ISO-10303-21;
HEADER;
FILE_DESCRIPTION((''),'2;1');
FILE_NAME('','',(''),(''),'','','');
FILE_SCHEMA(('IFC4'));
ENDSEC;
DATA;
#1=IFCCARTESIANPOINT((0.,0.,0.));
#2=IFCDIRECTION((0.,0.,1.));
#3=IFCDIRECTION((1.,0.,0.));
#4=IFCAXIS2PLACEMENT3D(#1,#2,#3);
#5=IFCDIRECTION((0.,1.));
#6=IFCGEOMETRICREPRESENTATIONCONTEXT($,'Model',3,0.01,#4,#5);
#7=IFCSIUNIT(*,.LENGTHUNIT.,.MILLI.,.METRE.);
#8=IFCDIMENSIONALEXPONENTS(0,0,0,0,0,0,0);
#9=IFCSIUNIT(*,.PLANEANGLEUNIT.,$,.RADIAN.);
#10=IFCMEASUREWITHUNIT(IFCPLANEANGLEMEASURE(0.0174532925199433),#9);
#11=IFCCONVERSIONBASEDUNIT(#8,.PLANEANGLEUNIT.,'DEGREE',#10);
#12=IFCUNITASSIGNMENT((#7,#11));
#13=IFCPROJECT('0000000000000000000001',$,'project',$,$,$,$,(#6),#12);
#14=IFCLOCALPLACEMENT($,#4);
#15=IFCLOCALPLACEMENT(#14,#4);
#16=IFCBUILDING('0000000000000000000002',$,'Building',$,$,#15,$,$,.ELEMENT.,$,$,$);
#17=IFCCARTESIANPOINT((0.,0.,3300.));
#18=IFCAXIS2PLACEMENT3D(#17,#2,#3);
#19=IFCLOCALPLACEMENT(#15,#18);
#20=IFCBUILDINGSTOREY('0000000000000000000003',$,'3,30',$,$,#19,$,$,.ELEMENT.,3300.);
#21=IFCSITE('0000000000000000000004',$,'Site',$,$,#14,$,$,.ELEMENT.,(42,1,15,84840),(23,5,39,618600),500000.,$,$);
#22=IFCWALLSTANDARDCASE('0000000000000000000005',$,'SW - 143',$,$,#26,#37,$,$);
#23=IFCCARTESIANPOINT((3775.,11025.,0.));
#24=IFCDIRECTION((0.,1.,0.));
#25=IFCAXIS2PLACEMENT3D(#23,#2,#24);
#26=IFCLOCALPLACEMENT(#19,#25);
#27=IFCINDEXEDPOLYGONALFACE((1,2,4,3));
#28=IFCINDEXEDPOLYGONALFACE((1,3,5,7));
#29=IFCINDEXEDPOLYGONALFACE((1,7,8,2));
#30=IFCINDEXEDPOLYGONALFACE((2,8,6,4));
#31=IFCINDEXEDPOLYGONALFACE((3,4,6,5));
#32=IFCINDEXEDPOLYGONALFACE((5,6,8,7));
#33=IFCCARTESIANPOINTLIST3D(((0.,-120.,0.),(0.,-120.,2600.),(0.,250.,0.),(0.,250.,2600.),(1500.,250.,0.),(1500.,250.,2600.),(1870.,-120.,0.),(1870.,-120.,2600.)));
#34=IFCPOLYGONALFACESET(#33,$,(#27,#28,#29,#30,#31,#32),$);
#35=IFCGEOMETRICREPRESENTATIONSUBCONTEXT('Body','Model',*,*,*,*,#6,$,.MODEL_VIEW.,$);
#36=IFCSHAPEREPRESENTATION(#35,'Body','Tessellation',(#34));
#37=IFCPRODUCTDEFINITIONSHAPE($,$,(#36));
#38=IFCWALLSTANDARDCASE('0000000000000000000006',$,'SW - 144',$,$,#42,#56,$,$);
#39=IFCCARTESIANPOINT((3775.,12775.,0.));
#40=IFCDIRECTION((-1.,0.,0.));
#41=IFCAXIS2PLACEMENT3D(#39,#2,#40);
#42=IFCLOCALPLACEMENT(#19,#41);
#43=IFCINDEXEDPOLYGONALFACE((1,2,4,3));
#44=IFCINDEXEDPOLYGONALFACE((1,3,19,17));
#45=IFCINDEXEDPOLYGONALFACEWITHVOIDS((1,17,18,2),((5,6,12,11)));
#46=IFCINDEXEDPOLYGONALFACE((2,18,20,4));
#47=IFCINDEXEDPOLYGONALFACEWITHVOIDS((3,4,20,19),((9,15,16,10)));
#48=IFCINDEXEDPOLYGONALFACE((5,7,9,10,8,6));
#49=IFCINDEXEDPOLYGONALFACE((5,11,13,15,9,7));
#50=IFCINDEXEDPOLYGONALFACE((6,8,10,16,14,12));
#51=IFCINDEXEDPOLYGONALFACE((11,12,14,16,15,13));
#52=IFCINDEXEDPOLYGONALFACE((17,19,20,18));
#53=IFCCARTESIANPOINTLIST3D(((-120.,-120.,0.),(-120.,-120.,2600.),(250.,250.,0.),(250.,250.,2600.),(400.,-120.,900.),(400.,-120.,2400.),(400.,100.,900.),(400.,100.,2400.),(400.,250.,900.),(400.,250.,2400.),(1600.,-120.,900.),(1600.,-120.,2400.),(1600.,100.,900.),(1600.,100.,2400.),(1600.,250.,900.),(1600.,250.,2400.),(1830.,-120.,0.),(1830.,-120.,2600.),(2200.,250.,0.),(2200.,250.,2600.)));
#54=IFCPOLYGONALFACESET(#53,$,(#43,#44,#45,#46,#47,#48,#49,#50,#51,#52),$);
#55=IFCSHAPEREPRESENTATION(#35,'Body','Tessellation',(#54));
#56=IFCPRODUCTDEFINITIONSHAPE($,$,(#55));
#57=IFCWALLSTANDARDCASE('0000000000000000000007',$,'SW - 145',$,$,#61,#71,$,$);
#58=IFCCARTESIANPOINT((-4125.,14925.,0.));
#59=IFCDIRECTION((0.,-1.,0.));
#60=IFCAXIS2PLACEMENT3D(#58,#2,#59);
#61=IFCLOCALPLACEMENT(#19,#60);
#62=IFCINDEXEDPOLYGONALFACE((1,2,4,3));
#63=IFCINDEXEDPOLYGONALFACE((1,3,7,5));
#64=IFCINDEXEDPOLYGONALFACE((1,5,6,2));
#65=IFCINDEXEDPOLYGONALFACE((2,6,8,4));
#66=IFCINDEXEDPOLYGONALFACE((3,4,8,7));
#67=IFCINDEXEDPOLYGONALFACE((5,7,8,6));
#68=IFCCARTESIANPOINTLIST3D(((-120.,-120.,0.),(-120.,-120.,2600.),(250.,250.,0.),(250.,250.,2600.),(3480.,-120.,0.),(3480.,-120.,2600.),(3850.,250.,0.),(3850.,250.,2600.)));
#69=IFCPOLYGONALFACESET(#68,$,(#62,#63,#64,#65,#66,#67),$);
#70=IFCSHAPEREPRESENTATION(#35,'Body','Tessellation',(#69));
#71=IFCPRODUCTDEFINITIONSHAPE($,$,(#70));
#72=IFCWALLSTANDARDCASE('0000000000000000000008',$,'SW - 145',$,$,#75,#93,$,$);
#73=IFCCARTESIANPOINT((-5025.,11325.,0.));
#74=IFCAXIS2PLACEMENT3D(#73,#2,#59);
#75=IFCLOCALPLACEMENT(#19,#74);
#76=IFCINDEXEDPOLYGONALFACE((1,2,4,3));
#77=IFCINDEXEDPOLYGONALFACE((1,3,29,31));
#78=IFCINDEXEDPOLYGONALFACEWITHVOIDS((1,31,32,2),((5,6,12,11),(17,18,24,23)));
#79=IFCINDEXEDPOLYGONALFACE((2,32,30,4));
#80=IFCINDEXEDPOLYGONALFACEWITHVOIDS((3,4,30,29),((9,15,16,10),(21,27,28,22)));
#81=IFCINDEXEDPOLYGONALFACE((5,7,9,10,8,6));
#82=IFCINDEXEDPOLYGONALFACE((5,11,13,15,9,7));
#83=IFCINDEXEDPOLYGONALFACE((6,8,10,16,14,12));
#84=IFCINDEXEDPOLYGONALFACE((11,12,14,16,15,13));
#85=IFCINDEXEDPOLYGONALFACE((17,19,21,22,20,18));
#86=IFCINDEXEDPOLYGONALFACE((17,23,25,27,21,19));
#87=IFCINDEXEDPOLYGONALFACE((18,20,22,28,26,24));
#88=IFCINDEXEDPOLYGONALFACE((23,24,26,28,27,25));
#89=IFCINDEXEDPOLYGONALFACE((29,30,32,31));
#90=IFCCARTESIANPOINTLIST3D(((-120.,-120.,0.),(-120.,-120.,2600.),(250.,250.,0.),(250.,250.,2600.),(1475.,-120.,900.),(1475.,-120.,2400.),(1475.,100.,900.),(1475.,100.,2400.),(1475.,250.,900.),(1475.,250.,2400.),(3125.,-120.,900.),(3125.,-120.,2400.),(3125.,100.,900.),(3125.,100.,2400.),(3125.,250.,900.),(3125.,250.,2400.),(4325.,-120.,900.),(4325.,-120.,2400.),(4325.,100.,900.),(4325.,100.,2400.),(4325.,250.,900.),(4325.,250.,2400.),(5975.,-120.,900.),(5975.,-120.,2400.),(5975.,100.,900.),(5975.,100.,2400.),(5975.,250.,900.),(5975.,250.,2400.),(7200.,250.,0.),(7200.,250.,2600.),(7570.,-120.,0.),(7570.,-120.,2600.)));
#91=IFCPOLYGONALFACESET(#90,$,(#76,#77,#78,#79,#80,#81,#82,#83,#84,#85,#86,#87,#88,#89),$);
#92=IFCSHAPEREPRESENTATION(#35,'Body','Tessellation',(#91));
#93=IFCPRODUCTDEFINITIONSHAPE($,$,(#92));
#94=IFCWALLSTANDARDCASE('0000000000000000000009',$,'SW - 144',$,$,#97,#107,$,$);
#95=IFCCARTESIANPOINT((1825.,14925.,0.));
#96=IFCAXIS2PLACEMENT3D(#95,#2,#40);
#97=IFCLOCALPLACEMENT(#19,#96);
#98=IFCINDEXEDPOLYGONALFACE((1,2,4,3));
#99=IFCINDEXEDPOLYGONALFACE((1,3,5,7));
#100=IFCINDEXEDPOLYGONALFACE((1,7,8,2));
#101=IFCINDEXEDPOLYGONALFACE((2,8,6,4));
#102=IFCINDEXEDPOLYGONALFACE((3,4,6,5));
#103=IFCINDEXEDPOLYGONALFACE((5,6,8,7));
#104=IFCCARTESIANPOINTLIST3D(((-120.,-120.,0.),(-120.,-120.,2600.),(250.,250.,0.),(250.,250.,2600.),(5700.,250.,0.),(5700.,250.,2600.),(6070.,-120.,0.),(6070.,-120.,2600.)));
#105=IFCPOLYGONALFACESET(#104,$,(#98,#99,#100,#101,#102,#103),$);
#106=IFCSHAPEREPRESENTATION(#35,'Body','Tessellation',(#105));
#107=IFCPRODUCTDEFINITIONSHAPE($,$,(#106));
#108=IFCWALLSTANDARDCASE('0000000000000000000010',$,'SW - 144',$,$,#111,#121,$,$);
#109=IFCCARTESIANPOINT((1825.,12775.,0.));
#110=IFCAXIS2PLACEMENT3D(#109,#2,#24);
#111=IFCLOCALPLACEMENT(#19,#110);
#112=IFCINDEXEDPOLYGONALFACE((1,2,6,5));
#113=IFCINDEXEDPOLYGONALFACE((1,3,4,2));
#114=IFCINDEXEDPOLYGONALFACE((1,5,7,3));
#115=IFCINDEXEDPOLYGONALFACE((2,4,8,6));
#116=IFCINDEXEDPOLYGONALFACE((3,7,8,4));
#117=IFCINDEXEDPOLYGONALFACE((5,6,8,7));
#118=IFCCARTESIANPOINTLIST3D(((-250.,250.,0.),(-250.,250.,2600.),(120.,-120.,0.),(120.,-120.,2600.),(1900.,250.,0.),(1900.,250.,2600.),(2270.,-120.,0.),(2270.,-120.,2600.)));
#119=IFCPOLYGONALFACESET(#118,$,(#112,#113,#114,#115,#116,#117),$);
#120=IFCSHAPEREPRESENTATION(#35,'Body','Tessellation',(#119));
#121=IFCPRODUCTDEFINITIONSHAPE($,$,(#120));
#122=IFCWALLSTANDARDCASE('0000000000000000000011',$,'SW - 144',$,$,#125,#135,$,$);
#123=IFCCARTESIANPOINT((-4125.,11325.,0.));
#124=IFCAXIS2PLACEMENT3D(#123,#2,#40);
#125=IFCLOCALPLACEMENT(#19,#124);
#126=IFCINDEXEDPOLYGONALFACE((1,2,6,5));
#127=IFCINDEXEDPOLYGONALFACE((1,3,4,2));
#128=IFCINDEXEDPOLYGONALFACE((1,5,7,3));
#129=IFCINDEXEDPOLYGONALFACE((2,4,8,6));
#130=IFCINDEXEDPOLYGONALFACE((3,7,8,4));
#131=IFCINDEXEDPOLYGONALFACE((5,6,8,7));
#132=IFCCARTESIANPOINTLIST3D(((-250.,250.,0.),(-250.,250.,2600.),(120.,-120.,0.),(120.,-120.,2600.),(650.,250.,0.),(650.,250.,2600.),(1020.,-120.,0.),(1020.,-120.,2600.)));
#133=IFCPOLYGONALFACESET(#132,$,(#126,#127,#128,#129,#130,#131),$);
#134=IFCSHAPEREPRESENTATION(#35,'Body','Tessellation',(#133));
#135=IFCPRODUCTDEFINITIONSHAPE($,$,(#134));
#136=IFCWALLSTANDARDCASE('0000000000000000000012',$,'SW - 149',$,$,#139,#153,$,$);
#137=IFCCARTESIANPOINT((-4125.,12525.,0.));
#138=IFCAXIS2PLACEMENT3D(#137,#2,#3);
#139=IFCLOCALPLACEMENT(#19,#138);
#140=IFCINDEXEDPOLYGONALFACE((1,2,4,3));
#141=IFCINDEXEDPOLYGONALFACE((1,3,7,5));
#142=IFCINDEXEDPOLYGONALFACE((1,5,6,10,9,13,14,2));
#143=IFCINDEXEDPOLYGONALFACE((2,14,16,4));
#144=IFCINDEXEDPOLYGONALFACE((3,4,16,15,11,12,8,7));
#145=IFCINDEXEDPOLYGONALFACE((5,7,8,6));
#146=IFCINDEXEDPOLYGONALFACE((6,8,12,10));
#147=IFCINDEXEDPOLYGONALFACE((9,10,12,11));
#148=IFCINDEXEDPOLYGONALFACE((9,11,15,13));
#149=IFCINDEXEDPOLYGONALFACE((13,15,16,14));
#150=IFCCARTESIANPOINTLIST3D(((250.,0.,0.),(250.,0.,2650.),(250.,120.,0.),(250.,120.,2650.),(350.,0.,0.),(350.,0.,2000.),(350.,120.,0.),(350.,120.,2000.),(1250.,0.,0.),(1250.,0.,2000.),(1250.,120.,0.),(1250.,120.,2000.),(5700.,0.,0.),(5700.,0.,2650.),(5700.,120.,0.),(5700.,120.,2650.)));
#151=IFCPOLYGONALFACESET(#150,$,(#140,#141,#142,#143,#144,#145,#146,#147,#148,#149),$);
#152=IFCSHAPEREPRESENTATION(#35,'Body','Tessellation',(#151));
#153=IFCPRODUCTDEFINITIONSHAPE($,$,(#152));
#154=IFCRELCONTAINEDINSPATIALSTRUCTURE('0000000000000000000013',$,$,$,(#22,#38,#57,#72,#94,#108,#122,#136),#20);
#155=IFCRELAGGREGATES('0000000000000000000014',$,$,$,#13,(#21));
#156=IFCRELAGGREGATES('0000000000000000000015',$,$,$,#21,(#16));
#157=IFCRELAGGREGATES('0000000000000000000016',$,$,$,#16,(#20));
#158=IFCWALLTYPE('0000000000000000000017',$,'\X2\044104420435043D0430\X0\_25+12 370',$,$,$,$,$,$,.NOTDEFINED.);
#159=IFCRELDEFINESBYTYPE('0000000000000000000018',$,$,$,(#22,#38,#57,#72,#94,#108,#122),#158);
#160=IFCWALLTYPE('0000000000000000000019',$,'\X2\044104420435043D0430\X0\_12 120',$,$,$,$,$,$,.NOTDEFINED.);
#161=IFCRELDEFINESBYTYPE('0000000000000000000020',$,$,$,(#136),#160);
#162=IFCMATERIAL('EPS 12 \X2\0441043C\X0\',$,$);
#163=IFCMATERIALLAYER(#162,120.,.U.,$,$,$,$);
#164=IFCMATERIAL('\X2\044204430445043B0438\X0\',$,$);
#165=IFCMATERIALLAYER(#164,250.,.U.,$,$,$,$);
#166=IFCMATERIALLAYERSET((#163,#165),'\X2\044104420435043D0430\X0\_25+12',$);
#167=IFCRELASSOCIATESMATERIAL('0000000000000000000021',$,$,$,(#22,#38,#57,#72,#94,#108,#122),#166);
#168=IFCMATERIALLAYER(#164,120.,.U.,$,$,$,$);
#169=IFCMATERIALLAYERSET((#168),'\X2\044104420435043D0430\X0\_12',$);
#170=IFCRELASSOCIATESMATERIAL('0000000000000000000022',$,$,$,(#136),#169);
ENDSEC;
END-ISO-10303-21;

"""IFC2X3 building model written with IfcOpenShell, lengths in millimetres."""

from ifc_helpers import new_model, entity, si_unit, converted_unit, direction, frame, origin_with_axes, origin_2d_with_axis, place, context, subcontext, project, spatial, polyline, rectangle, outline, extrude, material, layer, layer_set, layer_usage, type_object, element, save


model = new_model("IFC2X3")

# Units and contexts
model_context = context("Model", 3, precision=0.01, world=origin_with_axes(), true_north=direction((0.0, 1.0)))
body_context = subcontext(model_context, "Body", "Model", "MODEL_VIEW")
ifc_project = project(units=[si_unit("LENGTHUNIT", "METRE", prefix="MILLI"), converted_unit("PLANEANGLEUNIT", "DEGREE", entity("IfcPlaneAngleMeasure", 0.0174532925199433), si_unit("PLANEANGLEUNIT", "RADIAN"), dimensions=[0, 0, 0, 0, 0, 0, 0])], contexts=[model_context])

# Site, building, storey
site_placement = place(None, origin_with_axes())
site = spatial("IfcSite", under=ifc_project, at=site_placement, Name="Site", CompositionType="ELEMENT", RefLatitude=(42, 1, 15, 84840), RefLongitude=(23, 5, 39, 618600), RefElevation=500000.0)
building_placement = place(site_placement, origin_with_axes())
building = spatial("IfcBuilding", under=site, at=building_placement, Name="Building", CompositionType="ELEMENT")
storey_placement = place(building_placement, frame((0.0, 0.0, 3300.0), z_axis=(0.0, 0.0, 1.0), x_axis=(1.0, 0.0, 0.0)))
storey = spatial("IfcBuildingStorey", under=building, at=storey_placement, Name="3,30", CompositionType="ELEMENT", Elevation=3300.0)

# Wall
ifc_material_1 = material(Name="EPS 12 см")
ifc_layer_1 = layer(ifc_material_1, 120.0, ventilated="UNKNOWN")
ifc_material_2 = material(Name="тухли")
ifc_layer_2 = layer(ifc_material_2, 250.0, ventilated="UNKNOWN")
ifc_layer_set_1 = layer_set([ifc_layer_1, ifc_layer_2], Name="стена_25+12")
ifc_layer_usage_1 = layer_usage(ifc_layer_set_1, "AXIS2", "POSITIVE", -120.0)
wall_type_1 = type_object("IfcWallType", Name="стена_25+12 370", PredefinedType="NOTDEFINED")
wall_1_placement = place(storey_placement, frame((3775.0, 11025.0, 0.0), z_axis=(0.0, 0.0, 1.0), x_axis=(0.0, 1.0, 0.0)))
element("IfcWallStandardCase", 1, at=wall_1_placement, inside=storey, type_object=wall_type_1, material=ifc_layer_usage_1, Name="SW - 143", context=body_context, shape_type="SweptSolid", body=[
    extrude(outline(polyline([(0.0, -120.0), (1870.0, -120.0), (1500.0, 250.0), (0.0, 250.0), (0.0, -120.0)])), origin_with_axes(), (0.0, 0.0, 1.0), 2600.0),
])

# Wall, opening
ifc_layer_usage_2 = layer_usage(ifc_layer_set_1, "AXIS2", "POSITIVE", -120.0)
wall_2_placement = place(storey_placement, frame((3775.0, 12775.0, 0.0), z_axis=(0.0, 0.0, 1.0), x_axis=(-1.0, 0.0, 0.0)))
wall_2 = element("IfcWallStandardCase", 2, at=wall_2_placement, inside=storey, type_object=wall_type_1, material=ifc_layer_usage_2, Name="SW - 144", context=body_context, shape_type="SweptSolid", body=[
    extrude(outline(polyline([(-120.0, -120.0), (1830.0, -120.0), (2200.0, 250.0), (250.0, 250.0), (-120.0, -120.0)])), origin_with_axes(), (0.0, 0.0, 1.0), 2600.0),
])
opening_1_placement = place(wall_2_placement, frame((1000.0, 0.0, 900.0), z_axis=(0.0, 0.0, 1.0), x_axis=(1.0, 0.0, 0.0)))
element("IfcOpeningElement", 3, at=opening_1_placement, cuts=wall_2, context=body_context, shape_type="SweptSolid", body=[
    extrude(rectangle(XDim=1200.0, YDim=1500.0, at=origin_2d_with_axis()), frame((0.0, 100.0, 750.0), z_axis=(0.0, -1.0, 0.0), x_axis=(-1.0, 0.0, 0.0)), (0.0, 0.0, 1.0), 590.0),
    extrude(rectangle(XDim=1200.0, YDim=1500.0, at=origin_2d_with_axis()), frame((0.0, 100.0, 750.0), z_axis=(0.0, 1.0, 0.0), x_axis=(-1.0, 0.0, 0.0)), (0.0, 0.0, 1.0), 520.0),
])

# Wall
ifc_layer_usage_3 = layer_usage(ifc_layer_set_1, "AXIS2", "POSITIVE", -120.0)
wall_3_placement = place(storey_placement, frame((-4125.0, 14925.0, 0.0), z_axis=(0.0, 0.0, 1.0), x_axis=(0.0, -1.0, 0.0)))
element("IfcWallStandardCase", 4, at=wall_3_placement, inside=storey, type_object=wall_type_1, material=ifc_layer_usage_3, Name="SW - 145", context=body_context, shape_type="SweptSolid", body=[
    extrude(outline(polyline([(-120.0, -120.0), (3480.0, -120.0), (3850.0, 250.0), (250.0, 250.0), (-120.0, -120.0)])), origin_with_axes(), (0.0, 0.0, 1.0), 2600.0),
])

# Wall, openings
ifc_layer_usage_4 = layer_usage(ifc_layer_set_1, "AXIS2", "POSITIVE", -120.0)
wall_4_placement = place(storey_placement, frame((-5025.0, 11325.0, 0.0), z_axis=(0.0, 0.0, 1.0), x_axis=(0.0, -1.0, 0.0)))
wall_4 = element("IfcWallStandardCase", 5, at=wall_4_placement, inside=storey, type_object=wall_type_1, material=ifc_layer_usage_4, Name="SW - 145", context=body_context, shape_type="SweptSolid", body=[
    extrude(outline(polyline([(-120.0, -120.0), (7570.0, -120.0), (7200.0, 250.0), (250.0, 250.0), (-120.0, -120.0)])), origin_with_axes(), (0.0, 0.0, 1.0), 2600.0),
])
opening_2_placement = place(wall_4_placement, frame((2300.0, 0.0, 900.0), z_axis=(0.0, 0.0, 1.0), x_axis=(1.0, 0.0, 0.0)))
element("IfcOpeningElement", 6, at=opening_2_placement, cuts=wall_4, context=body_context, shape_type="SweptSolid", body=[
    extrude(rectangle(XDim=1650.0, YDim=1500.0, at=origin_2d_with_axis()), frame((0.0, 100.0, 750.0), z_axis=(0.0, 1.0, 0.0), x_axis=(1.0, 0.0, 0.0)), (0.0, 0.0, -1.0), 590.0),
    extrude(rectangle(XDim=1650.0, YDim=1500.0, at=origin_2d_with_axis()), frame((0.0, 100.0, 750.0), z_axis=(0.0, -1.0, 0.0), x_axis=(1.0, 0.0, 0.0)), (0.0, 0.0, -1.0), 520.0),
])
opening_3_placement = place(wall_4_placement, frame((5150.0, 0.0, 900.0), z_axis=(0.0, 0.0, 1.0), x_axis=(1.0, 0.0, 0.0)))
element("IfcOpeningElement", 7, at=opening_3_placement, cuts=wall_4, context=body_context, shape_type="SweptSolid", body=[
    extrude(rectangle(XDim=1650.0, YDim=1500.0, at=origin_2d_with_axis()), frame((0.0, 100.0, 750.0), z_axis=(0.0, -1.0, 0.0), x_axis=(-1.0, 0.0, 0.0)), (0.0, 0.0, 1.0), 590.0),
    extrude(rectangle(XDim=1650.0, YDim=1500.0, at=origin_2d_with_axis()), frame((0.0, 100.0, 750.0), z_axis=(0.0, 1.0, 0.0), x_axis=(-1.0, 0.0, 0.0)), (0.0, 0.0, 1.0), 520.0),
])

# Walls
ifc_layer_usage_5 = layer_usage(ifc_layer_set_1, "AXIS2", "POSITIVE", -120.0)
wall_5_placement = place(storey_placement, frame((1825.0, 14925.0, 0.0), z_axis=(0.0, 0.0, 1.0), x_axis=(-1.0, 0.0, 0.0)))
element("IfcWallStandardCase", 8, at=wall_5_placement, inside=storey, type_object=wall_type_1, material=ifc_layer_usage_5, Name="SW - 144", context=body_context, shape_type="SweptSolid", body=[
    extrude(outline(polyline([(-120.0, -120.0), (6070.0, -120.0), (5700.0, 250.0), (250.0, 250.0), (-120.0, -120.0)])), origin_with_axes(), (0.0, 0.0, 1.0), 2600.0),
])
ifc_layer_usage_6 = layer_usage(ifc_layer_set_1, "AXIS2", "POSITIVE", -120.0)
wall_6_placement = place(storey_placement, frame((1825.0, 12775.0, 0.0), z_axis=(0.0, 0.0, 1.0), x_axis=(0.0, 1.0, 0.0)))
element("IfcWallStandardCase", 9, at=wall_6_placement, inside=storey, type_object=wall_type_1, material=ifc_layer_usage_6, Name="SW - 144", context=body_context, shape_type="SweptSolid", body=[
    extrude(outline(polyline([(120.0, -120.0), (2270.0, -120.0), (1900.0, 250.0), (-250.0, 250.0), (120.0, -120.0)])), origin_with_axes(), (0.0, 0.0, 1.0), 2600.0),
])
ifc_layer_usage_7 = layer_usage(ifc_layer_set_1, "AXIS2", "POSITIVE", -120.0)
wall_7_placement = place(storey_placement, frame((-4125.0, 11325.0, 0.0), z_axis=(0.0, 0.0, 1.0), x_axis=(-1.0, 0.0, 0.0)))
element("IfcWallStandardCase", 10, at=wall_7_placement, inside=storey, type_object=wall_type_1, material=ifc_layer_usage_7, Name="SW - 144", context=body_context, shape_type="SweptSolid", body=[
    extrude(outline(polyline([(120.0, -120.0), (1020.0, -120.0), (650.0, 250.0), (-250.0, 250.0), (120.0, -120.0)])), origin_with_axes(), (0.0, 0.0, 1.0), 2600.0),
])

# Wall, opening
ifc_layer_3 = layer(ifc_material_2, 120.0, ventilated="UNKNOWN")
ifc_layer_set_2 = layer_set([ifc_layer_3], Name="стена_12")
ifc_layer_usage_8 = layer_usage(ifc_layer_set_2, "AXIS2", "POSITIVE", 0.0)
wall_type_2 = type_object("IfcWallType", Name="стена_12 120", PredefinedType="NOTDEFINED")
wall_8_placement = place(storey_placement, frame((-4125.0, 12525.0, 0.0), z_axis=(0.0, 0.0, 1.0), x_axis=(1.0, 0.0, 0.0)))
wall_8 = element("IfcWallStandardCase", 11, at=wall_8_placement, inside=storey, type_object=wall_type_2, material=ifc_layer_usage_8, Name="SW - 149", context=body_context, shape_type="SweptSolid", body=[
    extrude(outline(polyline([(250.0, 0.0), (5700.0, 0.0), (5700.0, 120.0), (250.0, 120.0), (250.0, 0.0)])), origin_with_axes(), (0.0, 0.0, 1.0), 2650.0),
])
opening_4_placement = place(wall_8_placement, frame((800.0, 0.0, 0.0), z_axis=(0.0, 0.0, 1.0), x_axis=(1.0, 0.0, 0.0)))
element("IfcOpeningElement", 12, at=opening_4_placement, cuts=wall_8, context=body_context, shape_type="SweptSolid", body=[
    extrude(rectangle(XDim=900.0, YDim=2000.0, at=origin_2d_with_axis()), frame((0.0, -120.0, 1000.0), z_axis=(0.0, -1.0, 0.0), x_axis=(-1.0, 0.0, 0.0)), (0.0, 0.0, -1.0), 360.0),
])

save(model, "model.ifc")
